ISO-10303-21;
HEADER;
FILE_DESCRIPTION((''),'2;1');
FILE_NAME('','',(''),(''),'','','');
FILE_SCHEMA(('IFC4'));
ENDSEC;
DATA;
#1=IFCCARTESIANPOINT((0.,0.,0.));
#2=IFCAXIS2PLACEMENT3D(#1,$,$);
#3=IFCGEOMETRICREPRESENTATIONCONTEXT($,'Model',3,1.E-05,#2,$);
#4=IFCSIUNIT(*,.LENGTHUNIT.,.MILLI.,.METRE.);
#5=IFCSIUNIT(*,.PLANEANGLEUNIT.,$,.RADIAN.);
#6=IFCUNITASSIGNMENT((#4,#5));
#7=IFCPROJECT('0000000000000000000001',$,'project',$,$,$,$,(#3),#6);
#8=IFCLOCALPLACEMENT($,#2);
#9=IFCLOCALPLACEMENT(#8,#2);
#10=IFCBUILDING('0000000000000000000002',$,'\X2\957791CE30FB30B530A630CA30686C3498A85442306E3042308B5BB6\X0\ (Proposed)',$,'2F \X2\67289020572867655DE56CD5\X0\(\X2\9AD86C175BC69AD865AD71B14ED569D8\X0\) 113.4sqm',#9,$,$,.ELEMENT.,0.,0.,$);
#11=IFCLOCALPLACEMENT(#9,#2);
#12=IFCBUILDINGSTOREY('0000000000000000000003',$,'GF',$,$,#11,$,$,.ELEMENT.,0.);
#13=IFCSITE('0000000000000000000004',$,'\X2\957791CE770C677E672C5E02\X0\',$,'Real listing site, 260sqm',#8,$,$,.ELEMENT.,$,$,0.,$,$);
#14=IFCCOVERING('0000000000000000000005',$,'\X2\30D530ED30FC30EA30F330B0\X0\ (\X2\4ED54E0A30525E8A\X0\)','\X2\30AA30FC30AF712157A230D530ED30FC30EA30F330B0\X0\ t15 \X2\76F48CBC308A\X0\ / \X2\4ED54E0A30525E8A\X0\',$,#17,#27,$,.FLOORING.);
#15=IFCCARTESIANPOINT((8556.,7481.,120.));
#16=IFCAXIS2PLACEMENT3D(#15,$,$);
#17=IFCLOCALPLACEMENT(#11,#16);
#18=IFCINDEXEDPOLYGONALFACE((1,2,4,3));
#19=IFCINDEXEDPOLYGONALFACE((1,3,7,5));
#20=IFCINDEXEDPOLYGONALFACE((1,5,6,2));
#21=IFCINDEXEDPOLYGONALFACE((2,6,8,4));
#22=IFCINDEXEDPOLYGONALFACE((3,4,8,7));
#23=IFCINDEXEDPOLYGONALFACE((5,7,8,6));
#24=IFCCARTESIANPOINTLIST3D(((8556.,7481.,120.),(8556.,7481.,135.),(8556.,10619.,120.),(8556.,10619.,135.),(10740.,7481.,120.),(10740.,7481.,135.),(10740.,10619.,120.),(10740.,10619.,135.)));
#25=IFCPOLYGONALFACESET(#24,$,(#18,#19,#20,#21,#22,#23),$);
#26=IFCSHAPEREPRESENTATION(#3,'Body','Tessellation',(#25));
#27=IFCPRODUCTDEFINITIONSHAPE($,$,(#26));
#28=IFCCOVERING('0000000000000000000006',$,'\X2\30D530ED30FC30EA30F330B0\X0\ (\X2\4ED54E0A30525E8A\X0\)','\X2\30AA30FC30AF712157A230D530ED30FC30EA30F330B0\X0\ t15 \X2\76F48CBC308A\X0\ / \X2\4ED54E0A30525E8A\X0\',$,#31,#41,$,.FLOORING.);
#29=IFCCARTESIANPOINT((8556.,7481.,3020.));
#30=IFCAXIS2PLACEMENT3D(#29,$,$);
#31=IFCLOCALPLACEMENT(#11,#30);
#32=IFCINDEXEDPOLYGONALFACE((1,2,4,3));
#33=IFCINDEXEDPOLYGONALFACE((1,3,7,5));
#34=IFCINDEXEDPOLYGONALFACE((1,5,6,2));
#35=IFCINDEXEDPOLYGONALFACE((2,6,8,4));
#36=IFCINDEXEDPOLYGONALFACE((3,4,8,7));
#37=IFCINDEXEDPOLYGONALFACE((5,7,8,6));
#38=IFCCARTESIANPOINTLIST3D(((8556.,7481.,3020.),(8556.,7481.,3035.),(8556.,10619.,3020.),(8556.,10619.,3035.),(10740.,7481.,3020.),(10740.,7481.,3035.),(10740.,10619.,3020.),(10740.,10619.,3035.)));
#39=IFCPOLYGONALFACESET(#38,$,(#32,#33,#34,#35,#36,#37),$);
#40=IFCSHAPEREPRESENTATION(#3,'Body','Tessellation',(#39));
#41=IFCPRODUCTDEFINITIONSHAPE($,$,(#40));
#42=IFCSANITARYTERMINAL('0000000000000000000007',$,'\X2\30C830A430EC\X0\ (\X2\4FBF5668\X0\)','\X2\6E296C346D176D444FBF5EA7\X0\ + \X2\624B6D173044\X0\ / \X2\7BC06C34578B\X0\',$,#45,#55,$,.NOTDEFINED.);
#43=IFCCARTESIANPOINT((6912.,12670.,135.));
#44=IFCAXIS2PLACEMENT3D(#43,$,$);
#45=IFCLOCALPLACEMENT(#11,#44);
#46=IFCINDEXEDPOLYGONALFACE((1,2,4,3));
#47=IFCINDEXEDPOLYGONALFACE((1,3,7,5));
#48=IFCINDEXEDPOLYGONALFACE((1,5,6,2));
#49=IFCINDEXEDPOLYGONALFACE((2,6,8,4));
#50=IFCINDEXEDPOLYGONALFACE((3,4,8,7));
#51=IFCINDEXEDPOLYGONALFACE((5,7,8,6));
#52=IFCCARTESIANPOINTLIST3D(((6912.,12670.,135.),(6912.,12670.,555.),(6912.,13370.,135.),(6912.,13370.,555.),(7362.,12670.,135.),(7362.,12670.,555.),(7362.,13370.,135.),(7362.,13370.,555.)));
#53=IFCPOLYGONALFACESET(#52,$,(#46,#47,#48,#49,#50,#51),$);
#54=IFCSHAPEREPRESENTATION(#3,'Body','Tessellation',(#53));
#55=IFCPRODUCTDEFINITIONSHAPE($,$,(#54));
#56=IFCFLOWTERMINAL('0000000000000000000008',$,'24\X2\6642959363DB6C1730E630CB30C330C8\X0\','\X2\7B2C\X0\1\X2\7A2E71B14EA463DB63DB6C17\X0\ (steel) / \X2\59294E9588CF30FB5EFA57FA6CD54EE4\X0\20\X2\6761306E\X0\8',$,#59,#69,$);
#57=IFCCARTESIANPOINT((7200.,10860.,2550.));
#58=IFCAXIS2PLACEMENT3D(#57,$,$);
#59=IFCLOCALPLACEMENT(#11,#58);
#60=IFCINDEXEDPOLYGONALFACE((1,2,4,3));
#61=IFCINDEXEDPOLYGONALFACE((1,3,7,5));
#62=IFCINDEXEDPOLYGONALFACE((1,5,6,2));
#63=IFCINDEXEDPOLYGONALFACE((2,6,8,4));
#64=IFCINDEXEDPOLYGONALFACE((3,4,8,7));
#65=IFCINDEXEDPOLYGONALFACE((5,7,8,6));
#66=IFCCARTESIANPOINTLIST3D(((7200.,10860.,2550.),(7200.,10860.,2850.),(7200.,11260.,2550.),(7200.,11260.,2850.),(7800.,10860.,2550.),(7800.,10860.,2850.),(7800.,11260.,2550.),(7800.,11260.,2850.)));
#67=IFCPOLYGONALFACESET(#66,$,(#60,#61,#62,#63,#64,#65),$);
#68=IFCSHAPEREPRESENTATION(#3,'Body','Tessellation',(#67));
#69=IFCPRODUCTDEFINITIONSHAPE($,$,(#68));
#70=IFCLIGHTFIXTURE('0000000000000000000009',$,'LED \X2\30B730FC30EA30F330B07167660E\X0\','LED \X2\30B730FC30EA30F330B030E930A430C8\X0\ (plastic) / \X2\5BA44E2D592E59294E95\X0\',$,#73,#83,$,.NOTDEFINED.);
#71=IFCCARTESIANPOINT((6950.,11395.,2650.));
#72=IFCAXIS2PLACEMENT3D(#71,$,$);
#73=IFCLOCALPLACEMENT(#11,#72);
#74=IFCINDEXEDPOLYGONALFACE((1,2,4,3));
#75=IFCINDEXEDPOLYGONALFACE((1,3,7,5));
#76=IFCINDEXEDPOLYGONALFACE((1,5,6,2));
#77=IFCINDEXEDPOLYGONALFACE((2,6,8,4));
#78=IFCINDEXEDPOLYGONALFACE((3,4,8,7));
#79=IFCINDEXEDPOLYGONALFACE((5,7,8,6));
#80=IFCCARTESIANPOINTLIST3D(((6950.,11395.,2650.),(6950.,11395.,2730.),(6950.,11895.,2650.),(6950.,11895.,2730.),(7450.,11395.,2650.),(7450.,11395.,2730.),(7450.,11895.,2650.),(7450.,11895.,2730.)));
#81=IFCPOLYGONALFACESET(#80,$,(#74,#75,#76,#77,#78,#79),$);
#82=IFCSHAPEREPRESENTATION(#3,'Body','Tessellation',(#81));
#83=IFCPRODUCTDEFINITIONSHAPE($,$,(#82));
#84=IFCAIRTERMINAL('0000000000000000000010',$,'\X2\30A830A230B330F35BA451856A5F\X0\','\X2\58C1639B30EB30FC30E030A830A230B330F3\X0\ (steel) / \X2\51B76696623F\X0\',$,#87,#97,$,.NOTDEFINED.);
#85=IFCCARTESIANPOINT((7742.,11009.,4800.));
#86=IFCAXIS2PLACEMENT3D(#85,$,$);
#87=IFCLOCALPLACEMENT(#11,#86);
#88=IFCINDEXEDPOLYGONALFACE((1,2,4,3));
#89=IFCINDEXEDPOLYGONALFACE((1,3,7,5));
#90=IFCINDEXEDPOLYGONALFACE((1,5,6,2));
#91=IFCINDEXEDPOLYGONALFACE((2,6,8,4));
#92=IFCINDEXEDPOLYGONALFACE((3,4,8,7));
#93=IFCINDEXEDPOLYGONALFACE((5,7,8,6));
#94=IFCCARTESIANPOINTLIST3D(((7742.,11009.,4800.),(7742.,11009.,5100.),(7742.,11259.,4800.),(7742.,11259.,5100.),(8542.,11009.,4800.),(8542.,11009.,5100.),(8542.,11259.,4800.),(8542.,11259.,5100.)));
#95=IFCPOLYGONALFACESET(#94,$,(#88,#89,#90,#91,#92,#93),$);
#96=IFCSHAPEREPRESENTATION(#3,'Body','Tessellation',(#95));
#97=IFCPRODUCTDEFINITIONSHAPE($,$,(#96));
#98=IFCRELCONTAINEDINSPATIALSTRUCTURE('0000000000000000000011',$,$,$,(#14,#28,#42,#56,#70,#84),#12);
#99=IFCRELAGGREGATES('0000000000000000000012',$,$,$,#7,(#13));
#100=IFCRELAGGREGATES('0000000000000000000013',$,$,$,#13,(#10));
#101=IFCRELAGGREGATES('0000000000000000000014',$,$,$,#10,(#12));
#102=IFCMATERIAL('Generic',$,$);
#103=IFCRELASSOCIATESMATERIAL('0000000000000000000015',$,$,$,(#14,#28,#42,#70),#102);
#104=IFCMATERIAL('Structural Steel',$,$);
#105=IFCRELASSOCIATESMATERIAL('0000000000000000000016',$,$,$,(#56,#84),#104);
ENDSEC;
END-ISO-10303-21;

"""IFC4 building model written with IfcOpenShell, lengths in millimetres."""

from ifc_helpers import new_model, si_unit, frame, frame_2d, origin, place, context, project, spatial, rectangle, extrude, material, element, save


model = new_model("IFC4")

# Units and contexts
model_context = context("Model", 3, precision=1e-05, world=origin())
ifc_project = project(units=[si_unit("LENGTHUNIT", "METRE", prefix="MILLI"), si_unit("PLANEANGLEUNIT", "RADIAN")], contexts=[model_context])

# Site, building, storey
site_placement = place(None, origin())
site = spatial("IfcSite", under=ifc_project, at=site_placement, Name="長野県松本市", ObjectType="Real listing site, 260sqm", CompositionType="ELEMENT", RefElevation=0.0)
building_placement = place(site_placement, origin())
building = spatial("IfcBuilding", under=site, at=building_placement, Name="長野・サウナと水風呂のある家 (Proposed)", ObjectType="2F 木造在来工法(高気密高断熱仕様) 113.4sqm", CompositionType="ELEMENT", ElevationOfRefHeight=0.0, ElevationOfTerrain=0.0)
storey_placement = place(building_placement, origin())
storey = spatial("IfcBuildingStorey", under=building, at=storey_placement, Name="GF", CompositionType="ELEMENT", Elevation=0.0)

# Coverings
ifc_material_1 = material(Name="Generic")
covering_1_placement = place(storey_placement, frame((8556.0, 7481.0, 120.0)))
element("IfcCovering", 1, at=covering_1_placement, inside=storey, material=ifc_material_1, Name="フローリング (仕上げ床)", Description="オーク無垢フローリング t15 直貼り / 仕上げ床", PredefinedType="FLOORING", context=model_context, shape_type="SweptSolid", body=[
    extrude(rectangle(XDim=2184.0, YDim=3138.0, at=frame_2d((1092.0, 1569.0))), frame((8556.0, 7481.0, 120.0)), (0.0, 0.0, 1.0), 15.0),
])
covering_2_placement = place(storey_placement, frame((8556.0, 7481.0, 3020.0)))
element("IfcCovering", 2, at=covering_2_placement, inside=storey, material=ifc_material_1, Name="フローリング (仕上げ床)", Description="オーク無垢フローリング t15 直貼り / 仕上げ床", PredefinedType="FLOORING", context=model_context, shape_type="SweptSolid", body=[
    extrude(rectangle(XDim=2184.0, YDim=3138.0, at=frame_2d((1092.0, 1569.0))), frame((8556.0, 7481.0, 3020.0)), (0.0, 0.0, 1.0), 15.0),
])

# Sanitary terminal
sanitary_terminal_placement = place(storey_placement, frame((6912.0, 12670.0, 135.0)))
element("IfcSanitaryTerminal", 3, at=sanitary_terminal_placement, inside=storey, material=ifc_material_1, Name="トイレ (便器)", Description="温水洗浄便座 + 手洗い / 節水型", PredefinedType="NOTDEFINED", context=model_context, shape_type="SweptSolid", body=[
    extrude(rectangle(XDim=450.0, YDim=700.0, at=frame_2d((225.0, 350.0))), frame((6912.0, 12670.0, 135.0)), (0.0, 0.0, 1.0), 420.0),
])

# Flow terminal
ifc_material_2 = material(Name="Structural Steel")
flow_terminal_placement = place(storey_placement, frame((7200.0, 10860.0, 2550.0)))
element("IfcFlowTerminal", 4, at=flow_terminal_placement, inside=storey, material=ifc_material_2, Name="24時間換気ユニット", Description="第1種熱交換換気 (steel) / 天井裏・建基法令20条の8", context=model_context, shape_type="SweptSolid", body=[
    extrude(rectangle(XDim=600.0, YDim=400.0, at=frame_2d((300.0, 200.0))), frame((7200.0, 10860.0, 2550.0)), (0.0, 0.0, 1.0), 300.0),
])

# Light fixture
light_fixture_placement = place(storey_placement, frame((6950.0, 11395.0, 2650.0)))
element("IfcLightFixture", 5, at=light_fixture_placement, inside=storey, material=ifc_material_1, Name="LED シーリング照明", Description="LED シーリングライト (plastic) / 室中央天井", PredefinedType="NOTDEFINED", context=model_context, shape_type="SweptSolid", body=[
    extrude(rectangle(XDim=500.0, YDim=500.0, at=frame_2d((250.0, 250.0))), frame((6950.0, 11395.0, 2650.0)), (0.0, 0.0, 1.0), 80.0),
])

# Air terminal
air_terminal_placement = place(storey_placement, frame((7742.0, 11009.0, 4800.0)))
element("IfcAirTerminal", 6, at=air_terminal_placement, inside=storey, material=ifc_material_2, Name="エアコン室内機", Description="壁掛ルームエアコン (steel) / 冷暖房", PredefinedType="NOTDEFINED", context=model_context, shape_type="SweptSolid", body=[
    extrude(rectangle(XDim=800.0, YDim=250.0, at=frame_2d((400.0, 125.0))), frame((7742.0, 11009.0, 4800.0)), (0.0, 0.0, 1.0), 300.0),
])

save(model, "model.ifc")
